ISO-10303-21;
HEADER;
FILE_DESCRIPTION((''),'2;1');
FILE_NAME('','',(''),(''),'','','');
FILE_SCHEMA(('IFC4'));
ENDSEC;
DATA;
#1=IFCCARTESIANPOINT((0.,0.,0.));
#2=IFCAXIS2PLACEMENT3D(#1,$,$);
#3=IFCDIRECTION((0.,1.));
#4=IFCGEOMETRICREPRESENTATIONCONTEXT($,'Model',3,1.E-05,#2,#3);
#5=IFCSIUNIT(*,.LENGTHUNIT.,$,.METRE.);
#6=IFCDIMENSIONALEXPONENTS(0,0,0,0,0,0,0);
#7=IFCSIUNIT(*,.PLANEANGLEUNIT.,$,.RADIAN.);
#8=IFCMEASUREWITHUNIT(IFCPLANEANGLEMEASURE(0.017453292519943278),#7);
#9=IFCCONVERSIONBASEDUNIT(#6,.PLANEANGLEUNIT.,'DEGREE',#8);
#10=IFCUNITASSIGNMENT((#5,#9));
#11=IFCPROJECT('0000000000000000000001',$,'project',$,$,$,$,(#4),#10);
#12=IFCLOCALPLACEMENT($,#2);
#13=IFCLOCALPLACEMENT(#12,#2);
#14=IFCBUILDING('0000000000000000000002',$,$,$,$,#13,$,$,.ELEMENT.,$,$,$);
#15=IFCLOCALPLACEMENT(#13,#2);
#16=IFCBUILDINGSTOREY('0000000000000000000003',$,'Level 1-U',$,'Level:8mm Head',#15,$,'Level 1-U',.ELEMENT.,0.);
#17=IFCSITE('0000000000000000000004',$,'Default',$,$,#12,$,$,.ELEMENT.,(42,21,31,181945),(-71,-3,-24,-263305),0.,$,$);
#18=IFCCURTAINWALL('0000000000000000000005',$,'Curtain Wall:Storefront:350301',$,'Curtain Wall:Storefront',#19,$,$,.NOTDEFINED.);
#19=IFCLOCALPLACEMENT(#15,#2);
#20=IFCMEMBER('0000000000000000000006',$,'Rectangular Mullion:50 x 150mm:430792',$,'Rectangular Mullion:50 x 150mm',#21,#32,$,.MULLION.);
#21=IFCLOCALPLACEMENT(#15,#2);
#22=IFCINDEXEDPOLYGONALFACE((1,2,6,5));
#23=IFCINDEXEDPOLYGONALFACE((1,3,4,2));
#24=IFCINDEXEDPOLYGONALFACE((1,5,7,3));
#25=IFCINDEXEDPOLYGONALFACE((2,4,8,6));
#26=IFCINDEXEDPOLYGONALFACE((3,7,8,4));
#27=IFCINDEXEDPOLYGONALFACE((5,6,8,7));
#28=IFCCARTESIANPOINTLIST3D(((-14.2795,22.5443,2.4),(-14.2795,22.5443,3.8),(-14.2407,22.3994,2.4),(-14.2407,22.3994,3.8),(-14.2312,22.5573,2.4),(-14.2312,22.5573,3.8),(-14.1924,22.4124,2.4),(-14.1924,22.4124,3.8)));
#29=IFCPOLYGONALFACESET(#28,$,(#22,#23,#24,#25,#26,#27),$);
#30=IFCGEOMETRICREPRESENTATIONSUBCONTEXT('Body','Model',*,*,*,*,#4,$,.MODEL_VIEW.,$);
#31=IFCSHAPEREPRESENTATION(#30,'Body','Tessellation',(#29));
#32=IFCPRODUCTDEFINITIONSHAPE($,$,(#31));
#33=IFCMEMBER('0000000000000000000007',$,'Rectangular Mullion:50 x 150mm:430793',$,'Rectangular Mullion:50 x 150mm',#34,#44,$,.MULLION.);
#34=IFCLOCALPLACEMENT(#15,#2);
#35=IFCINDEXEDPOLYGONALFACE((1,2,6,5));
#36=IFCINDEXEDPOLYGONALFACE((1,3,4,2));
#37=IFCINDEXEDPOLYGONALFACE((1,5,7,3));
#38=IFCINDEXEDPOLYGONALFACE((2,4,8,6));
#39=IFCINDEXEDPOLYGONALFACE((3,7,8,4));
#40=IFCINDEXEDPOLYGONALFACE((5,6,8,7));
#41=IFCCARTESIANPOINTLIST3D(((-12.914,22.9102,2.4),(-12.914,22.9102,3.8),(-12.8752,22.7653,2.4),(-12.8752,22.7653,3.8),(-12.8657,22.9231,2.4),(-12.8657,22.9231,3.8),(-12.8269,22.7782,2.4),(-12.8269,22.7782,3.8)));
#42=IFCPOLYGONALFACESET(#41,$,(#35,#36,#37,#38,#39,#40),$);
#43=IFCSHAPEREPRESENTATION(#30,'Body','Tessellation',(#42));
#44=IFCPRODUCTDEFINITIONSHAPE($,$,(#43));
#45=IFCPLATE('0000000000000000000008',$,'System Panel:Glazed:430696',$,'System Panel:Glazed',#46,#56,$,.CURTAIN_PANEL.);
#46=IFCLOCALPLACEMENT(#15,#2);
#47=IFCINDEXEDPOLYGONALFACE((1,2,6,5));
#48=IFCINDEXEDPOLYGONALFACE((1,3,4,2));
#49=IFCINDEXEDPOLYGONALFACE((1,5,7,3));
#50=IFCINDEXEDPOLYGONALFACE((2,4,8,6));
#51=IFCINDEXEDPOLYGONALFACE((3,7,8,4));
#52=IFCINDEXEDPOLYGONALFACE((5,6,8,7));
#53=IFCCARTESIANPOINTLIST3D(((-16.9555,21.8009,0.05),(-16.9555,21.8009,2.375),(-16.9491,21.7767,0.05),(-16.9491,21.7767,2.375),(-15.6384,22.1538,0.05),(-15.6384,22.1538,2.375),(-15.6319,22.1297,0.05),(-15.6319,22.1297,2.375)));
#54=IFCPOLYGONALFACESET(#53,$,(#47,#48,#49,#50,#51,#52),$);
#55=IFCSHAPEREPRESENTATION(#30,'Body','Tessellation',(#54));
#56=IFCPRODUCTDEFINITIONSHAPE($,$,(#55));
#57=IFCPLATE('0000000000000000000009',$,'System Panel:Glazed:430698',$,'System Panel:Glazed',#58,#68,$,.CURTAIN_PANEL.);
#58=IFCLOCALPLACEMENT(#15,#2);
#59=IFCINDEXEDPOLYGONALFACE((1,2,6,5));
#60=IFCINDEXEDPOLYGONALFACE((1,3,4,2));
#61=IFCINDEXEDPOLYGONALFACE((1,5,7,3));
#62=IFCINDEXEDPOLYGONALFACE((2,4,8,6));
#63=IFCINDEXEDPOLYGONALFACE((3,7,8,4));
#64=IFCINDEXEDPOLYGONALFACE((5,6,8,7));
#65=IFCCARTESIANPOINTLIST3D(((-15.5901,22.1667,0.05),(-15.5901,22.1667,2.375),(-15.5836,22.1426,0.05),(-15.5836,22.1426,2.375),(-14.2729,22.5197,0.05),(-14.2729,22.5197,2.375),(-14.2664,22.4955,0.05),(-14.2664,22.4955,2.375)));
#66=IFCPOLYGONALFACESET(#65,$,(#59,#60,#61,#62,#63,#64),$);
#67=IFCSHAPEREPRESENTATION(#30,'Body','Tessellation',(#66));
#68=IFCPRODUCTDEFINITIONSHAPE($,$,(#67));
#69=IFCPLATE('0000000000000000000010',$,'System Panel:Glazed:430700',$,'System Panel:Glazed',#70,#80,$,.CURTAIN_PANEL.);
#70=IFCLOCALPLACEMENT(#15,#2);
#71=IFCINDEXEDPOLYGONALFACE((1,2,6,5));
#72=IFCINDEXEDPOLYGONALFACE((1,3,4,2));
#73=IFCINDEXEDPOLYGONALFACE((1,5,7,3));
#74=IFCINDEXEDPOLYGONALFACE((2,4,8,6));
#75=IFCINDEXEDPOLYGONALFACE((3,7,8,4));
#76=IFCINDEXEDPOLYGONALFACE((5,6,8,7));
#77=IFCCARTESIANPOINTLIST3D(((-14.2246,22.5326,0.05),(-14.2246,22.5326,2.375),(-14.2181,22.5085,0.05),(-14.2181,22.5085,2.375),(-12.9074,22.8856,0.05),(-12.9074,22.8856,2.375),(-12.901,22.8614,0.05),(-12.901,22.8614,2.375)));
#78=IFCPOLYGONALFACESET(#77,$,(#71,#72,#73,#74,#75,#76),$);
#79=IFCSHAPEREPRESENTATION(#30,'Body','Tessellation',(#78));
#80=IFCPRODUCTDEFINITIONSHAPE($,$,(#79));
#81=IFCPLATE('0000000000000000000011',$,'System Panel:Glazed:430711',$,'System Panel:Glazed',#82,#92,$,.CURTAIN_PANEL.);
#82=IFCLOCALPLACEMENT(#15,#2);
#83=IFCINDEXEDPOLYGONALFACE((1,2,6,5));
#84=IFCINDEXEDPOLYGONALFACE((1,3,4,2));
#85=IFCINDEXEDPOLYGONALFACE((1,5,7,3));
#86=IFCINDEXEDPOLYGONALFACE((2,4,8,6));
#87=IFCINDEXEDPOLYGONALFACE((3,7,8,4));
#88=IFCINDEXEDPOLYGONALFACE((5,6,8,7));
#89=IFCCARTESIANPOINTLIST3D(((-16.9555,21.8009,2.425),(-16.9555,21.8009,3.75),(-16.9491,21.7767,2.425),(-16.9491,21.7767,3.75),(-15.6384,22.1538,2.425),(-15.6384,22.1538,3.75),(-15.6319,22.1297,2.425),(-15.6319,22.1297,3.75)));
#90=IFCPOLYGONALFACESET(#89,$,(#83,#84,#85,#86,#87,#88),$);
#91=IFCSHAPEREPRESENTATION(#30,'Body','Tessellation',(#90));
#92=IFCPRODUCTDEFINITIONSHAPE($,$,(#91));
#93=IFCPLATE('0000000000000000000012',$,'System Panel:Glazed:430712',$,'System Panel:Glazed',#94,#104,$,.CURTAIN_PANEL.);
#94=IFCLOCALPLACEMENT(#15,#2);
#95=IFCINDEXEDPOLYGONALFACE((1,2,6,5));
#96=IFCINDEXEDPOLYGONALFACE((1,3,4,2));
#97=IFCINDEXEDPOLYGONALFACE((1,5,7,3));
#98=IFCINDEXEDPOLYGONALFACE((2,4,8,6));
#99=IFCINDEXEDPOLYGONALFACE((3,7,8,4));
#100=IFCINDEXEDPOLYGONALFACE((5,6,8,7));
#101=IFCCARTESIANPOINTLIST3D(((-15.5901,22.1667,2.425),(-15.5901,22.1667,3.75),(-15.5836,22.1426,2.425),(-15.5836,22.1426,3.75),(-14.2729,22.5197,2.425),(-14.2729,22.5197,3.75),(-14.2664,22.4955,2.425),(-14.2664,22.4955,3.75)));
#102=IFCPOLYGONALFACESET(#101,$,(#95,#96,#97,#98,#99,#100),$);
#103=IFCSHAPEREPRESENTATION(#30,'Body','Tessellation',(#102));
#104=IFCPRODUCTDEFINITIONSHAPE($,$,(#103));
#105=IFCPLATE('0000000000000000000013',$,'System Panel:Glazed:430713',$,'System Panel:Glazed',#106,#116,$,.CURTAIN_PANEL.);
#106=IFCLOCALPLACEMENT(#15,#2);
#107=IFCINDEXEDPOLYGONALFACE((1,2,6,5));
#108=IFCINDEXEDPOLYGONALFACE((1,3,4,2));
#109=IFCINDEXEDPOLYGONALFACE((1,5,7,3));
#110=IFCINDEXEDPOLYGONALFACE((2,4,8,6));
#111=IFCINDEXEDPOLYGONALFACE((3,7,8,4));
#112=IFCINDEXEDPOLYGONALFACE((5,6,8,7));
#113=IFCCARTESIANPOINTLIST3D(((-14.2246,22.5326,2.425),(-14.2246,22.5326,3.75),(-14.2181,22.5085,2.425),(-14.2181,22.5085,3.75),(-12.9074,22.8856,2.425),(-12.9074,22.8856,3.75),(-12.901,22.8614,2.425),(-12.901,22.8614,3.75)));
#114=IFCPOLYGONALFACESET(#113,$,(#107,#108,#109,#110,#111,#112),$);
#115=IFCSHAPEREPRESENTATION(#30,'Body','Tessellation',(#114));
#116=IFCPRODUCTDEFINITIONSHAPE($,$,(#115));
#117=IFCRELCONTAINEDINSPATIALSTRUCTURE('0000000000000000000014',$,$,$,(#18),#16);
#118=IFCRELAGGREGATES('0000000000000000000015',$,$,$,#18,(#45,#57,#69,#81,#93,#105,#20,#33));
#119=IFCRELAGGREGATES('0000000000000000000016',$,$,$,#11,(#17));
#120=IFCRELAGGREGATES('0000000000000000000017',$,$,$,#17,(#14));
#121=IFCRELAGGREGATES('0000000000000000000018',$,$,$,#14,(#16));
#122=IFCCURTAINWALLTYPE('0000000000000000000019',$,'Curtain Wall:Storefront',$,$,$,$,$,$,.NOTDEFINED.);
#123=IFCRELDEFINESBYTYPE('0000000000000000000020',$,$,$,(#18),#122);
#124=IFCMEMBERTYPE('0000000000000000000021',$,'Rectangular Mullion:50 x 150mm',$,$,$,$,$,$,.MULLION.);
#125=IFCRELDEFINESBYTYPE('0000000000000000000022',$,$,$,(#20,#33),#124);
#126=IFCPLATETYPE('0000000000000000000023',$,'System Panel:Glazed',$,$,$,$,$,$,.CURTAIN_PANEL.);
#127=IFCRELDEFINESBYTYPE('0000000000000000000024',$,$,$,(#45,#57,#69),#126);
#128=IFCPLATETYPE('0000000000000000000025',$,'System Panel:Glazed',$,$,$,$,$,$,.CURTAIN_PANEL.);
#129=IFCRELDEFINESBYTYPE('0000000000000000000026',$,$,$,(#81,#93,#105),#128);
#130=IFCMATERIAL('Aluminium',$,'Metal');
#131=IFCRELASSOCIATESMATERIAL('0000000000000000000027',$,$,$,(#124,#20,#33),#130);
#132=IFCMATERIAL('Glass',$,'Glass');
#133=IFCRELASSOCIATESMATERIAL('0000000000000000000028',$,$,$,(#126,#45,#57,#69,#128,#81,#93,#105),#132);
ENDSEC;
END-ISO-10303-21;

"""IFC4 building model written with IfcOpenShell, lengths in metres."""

from ifc_helpers import new_model, entity, si_unit, converted_unit, direction, frame, origin, place, context, subcontext, project, spatial, indexed_curve, outline, extrude, source, transform, mapped, material, type_object, type_shapes, element, aggregate, save


model = new_model("IFC4")

# Units and contexts
model_context = context("Model", 3, precision=1e-05, world=origin(), true_north=direction((0.0, 1.0)))
body_context = subcontext(model_context, "Body", "Model", "MODEL_VIEW")
ifc_project = project(units=[si_unit("LENGTHUNIT", "METRE"), converted_unit("PLANEANGLEUNIT", "DEGREE", entity("IfcPlaneAngleMeasure", 0.017453292519943278), si_unit("PLANEANGLEUNIT", "RADIAN"), dimensions=[0, 0, 0, 0, 0, 0, 0])], contexts=[model_context])

# Site, building, storey
site_placement = place(None, origin())
site = spatial("IfcSite", under=ifc_project, at=site_placement, Name="Default", CompositionType="ELEMENT", RefLatitude=(42, 21, 31, 181945), RefLongitude=(-71, -3, -24, -263305), RefElevation=0.0)
building_placement = place(site_placement, origin())
building = spatial("IfcBuilding", under=site, at=building_placement, CompositionType="ELEMENT")
storey_placement = place(building_placement, origin())
storey = spatial("IfcBuildingStorey", under=building, at=storey_placement, Name="Level 1-U", ObjectType="Level:8mm Head", LongName="Level 1-U", CompositionType="ELEMENT", Elevation=0.0)

# Curtain wall, members, plates
curtain_wall_type = type_object("IfcCurtainWallType", Name="Curtain Wall:Storefront", PredefinedType="NOTDEFINED")
curtain_wall_placement = place(storey_placement, origin())
curtain_wall = element("IfcCurtainWall", 1, at=curtain_wall_placement, inside=storey, type_object=curtain_wall_type, Name="Curtain Wall:Storefront:350301", ObjectType="Curtain Wall:Storefront", PredefinedType="NOTDEFINED")
ifc_material_1 = material(Name="Aluminium", Category="Metal")
member_type_1 = type_object("IfcMemberType", Name="Rectangular Mullion:50 x 150mm", PredefinedType="MULLION", material=ifc_material_1)
shared_shape_1 = source(origin(), body_context, "Body", "SweptSolid", [
    extrude(outline(indexed_curve([(-0.025, -0.075), (0.025, -0.075), (0.025, 0.075), (-0.025, 0.075), (-0.025, -0.075)], self_intersect=False)), frame((0.0, 0.0, -1.4), z_axis=(0.0, 0.0, 1.0), x_axis=(-1.0, 0.0, 0.0)), (0.0, 0.0, 1.0), 1.4),
])
type_shapes(member_type_1, [shared_shape_1])
member_1_placement = place(curtain_wall_placement, frame((-14.2359, 22.4783, 2.4), z_axis=(0.0, 0.0, -1.0), x_axis=(0.965926, 0.258819, 0.0)))
member_1 = element("IfcMember", 2, at=member_1_placement, type_object=member_type_1, material=ifc_material_1, Name="Rectangular Mullion:50 x 150mm:430792", ObjectType="Rectangular Mullion:50 x 150mm", PredefinedType="MULLION", context=body_context, shape_type="MappedRepresentation", body=[
    mapped(shared_shape_1, transform((0.0, 0.0, 0.0), scale=1.0)),
])
member_2_placement = place(curtain_wall_placement, frame((-12.8705, 22.8442, 2.4), z_axis=(0.0, 0.0, -1.0), x_axis=(0.965926, 0.258819, 0.0)))
member_2 = element("IfcMember", 3, at=member_2_placement, type_object=member_type_1, material=ifc_material_1, Name="Rectangular Mullion:50 x 150mm:430793", ObjectType="Rectangular Mullion:50 x 150mm", PredefinedType="MULLION", context=body_context, shape_type="MappedRepresentation", body=[
    mapped(shared_shape_1, transform((0.0, 0.0, 0.0), scale=1.0)),
])
ifc_material_2 = material(Name="Glass", Category="Glass")
plate_type_1 = type_object("IfcPlateType", Name="System Panel:Glazed", PredefinedType="CURTAIN_PANEL", material=ifc_material_2)
shared_shape_2 = source(origin(), body_context, "Body", "SweptSolid", [
    extrude(outline(indexed_curve([(-0.0125, -0.6818), (0.0125, -0.6818), (0.0125, 0.6818), (-0.0125, 0.6818), (-0.0125, -0.6818)], self_intersect=False)), frame((0.0, 0.037, 0.0), z_axis=(0.0, 0.0, 1.0), x_axis=(0.0, 1.0, 0.0)), (0.0, 0.0, 1.0), 2.325),
])
type_shapes(plate_type_1, [shared_shape_2])
plate_1_placement = place(curtain_wall_placement, frame((-16.2841, 21.9295, 0.05), z_axis=(0.0, 0.0, 1.0), x_axis=(0.965926, 0.258819, 0.0)))
plate_1 = element("IfcPlate", 4, at=plate_1_placement, type_object=plate_type_1, material=ifc_material_2, Name="System Panel:Glazed:430696", ObjectType="System Panel:Glazed", PredefinedType="CURTAIN_PANEL", context=body_context, shape_type="MappedRepresentation", body=[
    mapped(shared_shape_2, transform((0.0, 0.0, 0.0), scale=1.0)),
])
plate_2_placement = place(curtain_wall_placement, frame((-14.9187, 22.2954, 0.05), z_axis=(0.0, 0.0, 1.0), x_axis=(0.965926, 0.258819, 0.0)))
plate_2 = element("IfcPlate", 5, at=plate_2_placement, type_object=plate_type_1, material=ifc_material_2, Name="System Panel:Glazed:430698", ObjectType="System Panel:Glazed", PredefinedType="CURTAIN_PANEL", context=body_context, shape_type="MappedRepresentation", body=[
    mapped(shared_shape_2, transform((0.0, 0.0, 0.0), scale=1.0)),
])
plate_3_placement = place(curtain_wall_placement, frame((-13.5532, 22.6613, 0.05), z_axis=(0.0, 0.0, 1.0), x_axis=(0.965926, 0.258819, 0.0)))
plate_3 = element("IfcPlate", 6, at=plate_3_placement, type_object=plate_type_1, material=ifc_material_2, Name="System Panel:Glazed:430700", ObjectType="System Panel:Glazed", PredefinedType="CURTAIN_PANEL", context=body_context, shape_type="MappedRepresentation", body=[
    mapped(shared_shape_2, transform((0.0, 0.0, 0.0), scale=1.0)),
])
plate_type_2 = type_object("IfcPlateType", Name="System Panel:Glazed", PredefinedType="CURTAIN_PANEL", material=ifc_material_2)
shared_shape_3 = source(origin(), body_context, "Body", "SweptSolid", [
    extrude(outline(indexed_curve([(-0.0125, -0.6818), (0.0125, -0.6818), (0.0125, 0.6818), (-0.0125, 0.6818), (-0.0125, -0.6818)], self_intersect=False)), frame((0.0, 0.037, 0.0), z_axis=(0.0, 0.0, 1.0), x_axis=(0.0, 1.0, 0.0)), (0.0, 0.0, 1.0), 1.325),
])
type_shapes(plate_type_2, [shared_shape_3])
plate_4_placement = place(curtain_wall_placement, frame((-16.2841, 21.9295, 2.425), z_axis=(0.0, 0.0, 1.0), x_axis=(0.965926, 0.258819, 0.0)))
plate_4 = element("IfcPlate", 7, at=plate_4_placement, type_object=plate_type_2, material=ifc_material_2, Name="System Panel:Glazed:430711", ObjectType="System Panel:Glazed", PredefinedType="CURTAIN_PANEL", context=body_context, shape_type="MappedRepresentation", body=[
    mapped(shared_shape_3, transform((0.0, 0.0, 0.0), scale=1.0)),
])
plate_5_placement = place(curtain_wall_placement, frame((-14.9187, 22.2954, 2.425), z_axis=(0.0, 0.0, 1.0), x_axis=(0.965926, 0.258819, 0.0)))
plate_5 = element("IfcPlate", 8, at=plate_5_placement, type_object=plate_type_2, material=ifc_material_2, Name="System Panel:Glazed:430712", ObjectType="System Panel:Glazed", PredefinedType="CURTAIN_PANEL", context=body_context, shape_type="MappedRepresentation", body=[
    mapped(shared_shape_3, transform((0.0, 0.0, 0.0), scale=1.0)),
])
plate_6_placement = place(curtain_wall_placement, frame((-13.5532, 22.6613, 2.425), z_axis=(0.0, 0.0, 1.0), x_axis=(0.965926, 0.258819, 0.0)))
plate_6 = element("IfcPlate", 9, at=plate_6_placement, type_object=plate_type_2, material=ifc_material_2, Name="System Panel:Glazed:430713", ObjectType="System Panel:Glazed", PredefinedType="CURTAIN_PANEL", context=body_context, shape_type="MappedRepresentation", body=[
    mapped(shared_shape_3, transform((0.0, 0.0, 0.0), scale=1.0)),
])
aggregate(curtain_wall, [plate_1, plate_2, plate_3, plate_4, plate_5, plate_6, member_1, member_2])

save(model, "model.ifc")
